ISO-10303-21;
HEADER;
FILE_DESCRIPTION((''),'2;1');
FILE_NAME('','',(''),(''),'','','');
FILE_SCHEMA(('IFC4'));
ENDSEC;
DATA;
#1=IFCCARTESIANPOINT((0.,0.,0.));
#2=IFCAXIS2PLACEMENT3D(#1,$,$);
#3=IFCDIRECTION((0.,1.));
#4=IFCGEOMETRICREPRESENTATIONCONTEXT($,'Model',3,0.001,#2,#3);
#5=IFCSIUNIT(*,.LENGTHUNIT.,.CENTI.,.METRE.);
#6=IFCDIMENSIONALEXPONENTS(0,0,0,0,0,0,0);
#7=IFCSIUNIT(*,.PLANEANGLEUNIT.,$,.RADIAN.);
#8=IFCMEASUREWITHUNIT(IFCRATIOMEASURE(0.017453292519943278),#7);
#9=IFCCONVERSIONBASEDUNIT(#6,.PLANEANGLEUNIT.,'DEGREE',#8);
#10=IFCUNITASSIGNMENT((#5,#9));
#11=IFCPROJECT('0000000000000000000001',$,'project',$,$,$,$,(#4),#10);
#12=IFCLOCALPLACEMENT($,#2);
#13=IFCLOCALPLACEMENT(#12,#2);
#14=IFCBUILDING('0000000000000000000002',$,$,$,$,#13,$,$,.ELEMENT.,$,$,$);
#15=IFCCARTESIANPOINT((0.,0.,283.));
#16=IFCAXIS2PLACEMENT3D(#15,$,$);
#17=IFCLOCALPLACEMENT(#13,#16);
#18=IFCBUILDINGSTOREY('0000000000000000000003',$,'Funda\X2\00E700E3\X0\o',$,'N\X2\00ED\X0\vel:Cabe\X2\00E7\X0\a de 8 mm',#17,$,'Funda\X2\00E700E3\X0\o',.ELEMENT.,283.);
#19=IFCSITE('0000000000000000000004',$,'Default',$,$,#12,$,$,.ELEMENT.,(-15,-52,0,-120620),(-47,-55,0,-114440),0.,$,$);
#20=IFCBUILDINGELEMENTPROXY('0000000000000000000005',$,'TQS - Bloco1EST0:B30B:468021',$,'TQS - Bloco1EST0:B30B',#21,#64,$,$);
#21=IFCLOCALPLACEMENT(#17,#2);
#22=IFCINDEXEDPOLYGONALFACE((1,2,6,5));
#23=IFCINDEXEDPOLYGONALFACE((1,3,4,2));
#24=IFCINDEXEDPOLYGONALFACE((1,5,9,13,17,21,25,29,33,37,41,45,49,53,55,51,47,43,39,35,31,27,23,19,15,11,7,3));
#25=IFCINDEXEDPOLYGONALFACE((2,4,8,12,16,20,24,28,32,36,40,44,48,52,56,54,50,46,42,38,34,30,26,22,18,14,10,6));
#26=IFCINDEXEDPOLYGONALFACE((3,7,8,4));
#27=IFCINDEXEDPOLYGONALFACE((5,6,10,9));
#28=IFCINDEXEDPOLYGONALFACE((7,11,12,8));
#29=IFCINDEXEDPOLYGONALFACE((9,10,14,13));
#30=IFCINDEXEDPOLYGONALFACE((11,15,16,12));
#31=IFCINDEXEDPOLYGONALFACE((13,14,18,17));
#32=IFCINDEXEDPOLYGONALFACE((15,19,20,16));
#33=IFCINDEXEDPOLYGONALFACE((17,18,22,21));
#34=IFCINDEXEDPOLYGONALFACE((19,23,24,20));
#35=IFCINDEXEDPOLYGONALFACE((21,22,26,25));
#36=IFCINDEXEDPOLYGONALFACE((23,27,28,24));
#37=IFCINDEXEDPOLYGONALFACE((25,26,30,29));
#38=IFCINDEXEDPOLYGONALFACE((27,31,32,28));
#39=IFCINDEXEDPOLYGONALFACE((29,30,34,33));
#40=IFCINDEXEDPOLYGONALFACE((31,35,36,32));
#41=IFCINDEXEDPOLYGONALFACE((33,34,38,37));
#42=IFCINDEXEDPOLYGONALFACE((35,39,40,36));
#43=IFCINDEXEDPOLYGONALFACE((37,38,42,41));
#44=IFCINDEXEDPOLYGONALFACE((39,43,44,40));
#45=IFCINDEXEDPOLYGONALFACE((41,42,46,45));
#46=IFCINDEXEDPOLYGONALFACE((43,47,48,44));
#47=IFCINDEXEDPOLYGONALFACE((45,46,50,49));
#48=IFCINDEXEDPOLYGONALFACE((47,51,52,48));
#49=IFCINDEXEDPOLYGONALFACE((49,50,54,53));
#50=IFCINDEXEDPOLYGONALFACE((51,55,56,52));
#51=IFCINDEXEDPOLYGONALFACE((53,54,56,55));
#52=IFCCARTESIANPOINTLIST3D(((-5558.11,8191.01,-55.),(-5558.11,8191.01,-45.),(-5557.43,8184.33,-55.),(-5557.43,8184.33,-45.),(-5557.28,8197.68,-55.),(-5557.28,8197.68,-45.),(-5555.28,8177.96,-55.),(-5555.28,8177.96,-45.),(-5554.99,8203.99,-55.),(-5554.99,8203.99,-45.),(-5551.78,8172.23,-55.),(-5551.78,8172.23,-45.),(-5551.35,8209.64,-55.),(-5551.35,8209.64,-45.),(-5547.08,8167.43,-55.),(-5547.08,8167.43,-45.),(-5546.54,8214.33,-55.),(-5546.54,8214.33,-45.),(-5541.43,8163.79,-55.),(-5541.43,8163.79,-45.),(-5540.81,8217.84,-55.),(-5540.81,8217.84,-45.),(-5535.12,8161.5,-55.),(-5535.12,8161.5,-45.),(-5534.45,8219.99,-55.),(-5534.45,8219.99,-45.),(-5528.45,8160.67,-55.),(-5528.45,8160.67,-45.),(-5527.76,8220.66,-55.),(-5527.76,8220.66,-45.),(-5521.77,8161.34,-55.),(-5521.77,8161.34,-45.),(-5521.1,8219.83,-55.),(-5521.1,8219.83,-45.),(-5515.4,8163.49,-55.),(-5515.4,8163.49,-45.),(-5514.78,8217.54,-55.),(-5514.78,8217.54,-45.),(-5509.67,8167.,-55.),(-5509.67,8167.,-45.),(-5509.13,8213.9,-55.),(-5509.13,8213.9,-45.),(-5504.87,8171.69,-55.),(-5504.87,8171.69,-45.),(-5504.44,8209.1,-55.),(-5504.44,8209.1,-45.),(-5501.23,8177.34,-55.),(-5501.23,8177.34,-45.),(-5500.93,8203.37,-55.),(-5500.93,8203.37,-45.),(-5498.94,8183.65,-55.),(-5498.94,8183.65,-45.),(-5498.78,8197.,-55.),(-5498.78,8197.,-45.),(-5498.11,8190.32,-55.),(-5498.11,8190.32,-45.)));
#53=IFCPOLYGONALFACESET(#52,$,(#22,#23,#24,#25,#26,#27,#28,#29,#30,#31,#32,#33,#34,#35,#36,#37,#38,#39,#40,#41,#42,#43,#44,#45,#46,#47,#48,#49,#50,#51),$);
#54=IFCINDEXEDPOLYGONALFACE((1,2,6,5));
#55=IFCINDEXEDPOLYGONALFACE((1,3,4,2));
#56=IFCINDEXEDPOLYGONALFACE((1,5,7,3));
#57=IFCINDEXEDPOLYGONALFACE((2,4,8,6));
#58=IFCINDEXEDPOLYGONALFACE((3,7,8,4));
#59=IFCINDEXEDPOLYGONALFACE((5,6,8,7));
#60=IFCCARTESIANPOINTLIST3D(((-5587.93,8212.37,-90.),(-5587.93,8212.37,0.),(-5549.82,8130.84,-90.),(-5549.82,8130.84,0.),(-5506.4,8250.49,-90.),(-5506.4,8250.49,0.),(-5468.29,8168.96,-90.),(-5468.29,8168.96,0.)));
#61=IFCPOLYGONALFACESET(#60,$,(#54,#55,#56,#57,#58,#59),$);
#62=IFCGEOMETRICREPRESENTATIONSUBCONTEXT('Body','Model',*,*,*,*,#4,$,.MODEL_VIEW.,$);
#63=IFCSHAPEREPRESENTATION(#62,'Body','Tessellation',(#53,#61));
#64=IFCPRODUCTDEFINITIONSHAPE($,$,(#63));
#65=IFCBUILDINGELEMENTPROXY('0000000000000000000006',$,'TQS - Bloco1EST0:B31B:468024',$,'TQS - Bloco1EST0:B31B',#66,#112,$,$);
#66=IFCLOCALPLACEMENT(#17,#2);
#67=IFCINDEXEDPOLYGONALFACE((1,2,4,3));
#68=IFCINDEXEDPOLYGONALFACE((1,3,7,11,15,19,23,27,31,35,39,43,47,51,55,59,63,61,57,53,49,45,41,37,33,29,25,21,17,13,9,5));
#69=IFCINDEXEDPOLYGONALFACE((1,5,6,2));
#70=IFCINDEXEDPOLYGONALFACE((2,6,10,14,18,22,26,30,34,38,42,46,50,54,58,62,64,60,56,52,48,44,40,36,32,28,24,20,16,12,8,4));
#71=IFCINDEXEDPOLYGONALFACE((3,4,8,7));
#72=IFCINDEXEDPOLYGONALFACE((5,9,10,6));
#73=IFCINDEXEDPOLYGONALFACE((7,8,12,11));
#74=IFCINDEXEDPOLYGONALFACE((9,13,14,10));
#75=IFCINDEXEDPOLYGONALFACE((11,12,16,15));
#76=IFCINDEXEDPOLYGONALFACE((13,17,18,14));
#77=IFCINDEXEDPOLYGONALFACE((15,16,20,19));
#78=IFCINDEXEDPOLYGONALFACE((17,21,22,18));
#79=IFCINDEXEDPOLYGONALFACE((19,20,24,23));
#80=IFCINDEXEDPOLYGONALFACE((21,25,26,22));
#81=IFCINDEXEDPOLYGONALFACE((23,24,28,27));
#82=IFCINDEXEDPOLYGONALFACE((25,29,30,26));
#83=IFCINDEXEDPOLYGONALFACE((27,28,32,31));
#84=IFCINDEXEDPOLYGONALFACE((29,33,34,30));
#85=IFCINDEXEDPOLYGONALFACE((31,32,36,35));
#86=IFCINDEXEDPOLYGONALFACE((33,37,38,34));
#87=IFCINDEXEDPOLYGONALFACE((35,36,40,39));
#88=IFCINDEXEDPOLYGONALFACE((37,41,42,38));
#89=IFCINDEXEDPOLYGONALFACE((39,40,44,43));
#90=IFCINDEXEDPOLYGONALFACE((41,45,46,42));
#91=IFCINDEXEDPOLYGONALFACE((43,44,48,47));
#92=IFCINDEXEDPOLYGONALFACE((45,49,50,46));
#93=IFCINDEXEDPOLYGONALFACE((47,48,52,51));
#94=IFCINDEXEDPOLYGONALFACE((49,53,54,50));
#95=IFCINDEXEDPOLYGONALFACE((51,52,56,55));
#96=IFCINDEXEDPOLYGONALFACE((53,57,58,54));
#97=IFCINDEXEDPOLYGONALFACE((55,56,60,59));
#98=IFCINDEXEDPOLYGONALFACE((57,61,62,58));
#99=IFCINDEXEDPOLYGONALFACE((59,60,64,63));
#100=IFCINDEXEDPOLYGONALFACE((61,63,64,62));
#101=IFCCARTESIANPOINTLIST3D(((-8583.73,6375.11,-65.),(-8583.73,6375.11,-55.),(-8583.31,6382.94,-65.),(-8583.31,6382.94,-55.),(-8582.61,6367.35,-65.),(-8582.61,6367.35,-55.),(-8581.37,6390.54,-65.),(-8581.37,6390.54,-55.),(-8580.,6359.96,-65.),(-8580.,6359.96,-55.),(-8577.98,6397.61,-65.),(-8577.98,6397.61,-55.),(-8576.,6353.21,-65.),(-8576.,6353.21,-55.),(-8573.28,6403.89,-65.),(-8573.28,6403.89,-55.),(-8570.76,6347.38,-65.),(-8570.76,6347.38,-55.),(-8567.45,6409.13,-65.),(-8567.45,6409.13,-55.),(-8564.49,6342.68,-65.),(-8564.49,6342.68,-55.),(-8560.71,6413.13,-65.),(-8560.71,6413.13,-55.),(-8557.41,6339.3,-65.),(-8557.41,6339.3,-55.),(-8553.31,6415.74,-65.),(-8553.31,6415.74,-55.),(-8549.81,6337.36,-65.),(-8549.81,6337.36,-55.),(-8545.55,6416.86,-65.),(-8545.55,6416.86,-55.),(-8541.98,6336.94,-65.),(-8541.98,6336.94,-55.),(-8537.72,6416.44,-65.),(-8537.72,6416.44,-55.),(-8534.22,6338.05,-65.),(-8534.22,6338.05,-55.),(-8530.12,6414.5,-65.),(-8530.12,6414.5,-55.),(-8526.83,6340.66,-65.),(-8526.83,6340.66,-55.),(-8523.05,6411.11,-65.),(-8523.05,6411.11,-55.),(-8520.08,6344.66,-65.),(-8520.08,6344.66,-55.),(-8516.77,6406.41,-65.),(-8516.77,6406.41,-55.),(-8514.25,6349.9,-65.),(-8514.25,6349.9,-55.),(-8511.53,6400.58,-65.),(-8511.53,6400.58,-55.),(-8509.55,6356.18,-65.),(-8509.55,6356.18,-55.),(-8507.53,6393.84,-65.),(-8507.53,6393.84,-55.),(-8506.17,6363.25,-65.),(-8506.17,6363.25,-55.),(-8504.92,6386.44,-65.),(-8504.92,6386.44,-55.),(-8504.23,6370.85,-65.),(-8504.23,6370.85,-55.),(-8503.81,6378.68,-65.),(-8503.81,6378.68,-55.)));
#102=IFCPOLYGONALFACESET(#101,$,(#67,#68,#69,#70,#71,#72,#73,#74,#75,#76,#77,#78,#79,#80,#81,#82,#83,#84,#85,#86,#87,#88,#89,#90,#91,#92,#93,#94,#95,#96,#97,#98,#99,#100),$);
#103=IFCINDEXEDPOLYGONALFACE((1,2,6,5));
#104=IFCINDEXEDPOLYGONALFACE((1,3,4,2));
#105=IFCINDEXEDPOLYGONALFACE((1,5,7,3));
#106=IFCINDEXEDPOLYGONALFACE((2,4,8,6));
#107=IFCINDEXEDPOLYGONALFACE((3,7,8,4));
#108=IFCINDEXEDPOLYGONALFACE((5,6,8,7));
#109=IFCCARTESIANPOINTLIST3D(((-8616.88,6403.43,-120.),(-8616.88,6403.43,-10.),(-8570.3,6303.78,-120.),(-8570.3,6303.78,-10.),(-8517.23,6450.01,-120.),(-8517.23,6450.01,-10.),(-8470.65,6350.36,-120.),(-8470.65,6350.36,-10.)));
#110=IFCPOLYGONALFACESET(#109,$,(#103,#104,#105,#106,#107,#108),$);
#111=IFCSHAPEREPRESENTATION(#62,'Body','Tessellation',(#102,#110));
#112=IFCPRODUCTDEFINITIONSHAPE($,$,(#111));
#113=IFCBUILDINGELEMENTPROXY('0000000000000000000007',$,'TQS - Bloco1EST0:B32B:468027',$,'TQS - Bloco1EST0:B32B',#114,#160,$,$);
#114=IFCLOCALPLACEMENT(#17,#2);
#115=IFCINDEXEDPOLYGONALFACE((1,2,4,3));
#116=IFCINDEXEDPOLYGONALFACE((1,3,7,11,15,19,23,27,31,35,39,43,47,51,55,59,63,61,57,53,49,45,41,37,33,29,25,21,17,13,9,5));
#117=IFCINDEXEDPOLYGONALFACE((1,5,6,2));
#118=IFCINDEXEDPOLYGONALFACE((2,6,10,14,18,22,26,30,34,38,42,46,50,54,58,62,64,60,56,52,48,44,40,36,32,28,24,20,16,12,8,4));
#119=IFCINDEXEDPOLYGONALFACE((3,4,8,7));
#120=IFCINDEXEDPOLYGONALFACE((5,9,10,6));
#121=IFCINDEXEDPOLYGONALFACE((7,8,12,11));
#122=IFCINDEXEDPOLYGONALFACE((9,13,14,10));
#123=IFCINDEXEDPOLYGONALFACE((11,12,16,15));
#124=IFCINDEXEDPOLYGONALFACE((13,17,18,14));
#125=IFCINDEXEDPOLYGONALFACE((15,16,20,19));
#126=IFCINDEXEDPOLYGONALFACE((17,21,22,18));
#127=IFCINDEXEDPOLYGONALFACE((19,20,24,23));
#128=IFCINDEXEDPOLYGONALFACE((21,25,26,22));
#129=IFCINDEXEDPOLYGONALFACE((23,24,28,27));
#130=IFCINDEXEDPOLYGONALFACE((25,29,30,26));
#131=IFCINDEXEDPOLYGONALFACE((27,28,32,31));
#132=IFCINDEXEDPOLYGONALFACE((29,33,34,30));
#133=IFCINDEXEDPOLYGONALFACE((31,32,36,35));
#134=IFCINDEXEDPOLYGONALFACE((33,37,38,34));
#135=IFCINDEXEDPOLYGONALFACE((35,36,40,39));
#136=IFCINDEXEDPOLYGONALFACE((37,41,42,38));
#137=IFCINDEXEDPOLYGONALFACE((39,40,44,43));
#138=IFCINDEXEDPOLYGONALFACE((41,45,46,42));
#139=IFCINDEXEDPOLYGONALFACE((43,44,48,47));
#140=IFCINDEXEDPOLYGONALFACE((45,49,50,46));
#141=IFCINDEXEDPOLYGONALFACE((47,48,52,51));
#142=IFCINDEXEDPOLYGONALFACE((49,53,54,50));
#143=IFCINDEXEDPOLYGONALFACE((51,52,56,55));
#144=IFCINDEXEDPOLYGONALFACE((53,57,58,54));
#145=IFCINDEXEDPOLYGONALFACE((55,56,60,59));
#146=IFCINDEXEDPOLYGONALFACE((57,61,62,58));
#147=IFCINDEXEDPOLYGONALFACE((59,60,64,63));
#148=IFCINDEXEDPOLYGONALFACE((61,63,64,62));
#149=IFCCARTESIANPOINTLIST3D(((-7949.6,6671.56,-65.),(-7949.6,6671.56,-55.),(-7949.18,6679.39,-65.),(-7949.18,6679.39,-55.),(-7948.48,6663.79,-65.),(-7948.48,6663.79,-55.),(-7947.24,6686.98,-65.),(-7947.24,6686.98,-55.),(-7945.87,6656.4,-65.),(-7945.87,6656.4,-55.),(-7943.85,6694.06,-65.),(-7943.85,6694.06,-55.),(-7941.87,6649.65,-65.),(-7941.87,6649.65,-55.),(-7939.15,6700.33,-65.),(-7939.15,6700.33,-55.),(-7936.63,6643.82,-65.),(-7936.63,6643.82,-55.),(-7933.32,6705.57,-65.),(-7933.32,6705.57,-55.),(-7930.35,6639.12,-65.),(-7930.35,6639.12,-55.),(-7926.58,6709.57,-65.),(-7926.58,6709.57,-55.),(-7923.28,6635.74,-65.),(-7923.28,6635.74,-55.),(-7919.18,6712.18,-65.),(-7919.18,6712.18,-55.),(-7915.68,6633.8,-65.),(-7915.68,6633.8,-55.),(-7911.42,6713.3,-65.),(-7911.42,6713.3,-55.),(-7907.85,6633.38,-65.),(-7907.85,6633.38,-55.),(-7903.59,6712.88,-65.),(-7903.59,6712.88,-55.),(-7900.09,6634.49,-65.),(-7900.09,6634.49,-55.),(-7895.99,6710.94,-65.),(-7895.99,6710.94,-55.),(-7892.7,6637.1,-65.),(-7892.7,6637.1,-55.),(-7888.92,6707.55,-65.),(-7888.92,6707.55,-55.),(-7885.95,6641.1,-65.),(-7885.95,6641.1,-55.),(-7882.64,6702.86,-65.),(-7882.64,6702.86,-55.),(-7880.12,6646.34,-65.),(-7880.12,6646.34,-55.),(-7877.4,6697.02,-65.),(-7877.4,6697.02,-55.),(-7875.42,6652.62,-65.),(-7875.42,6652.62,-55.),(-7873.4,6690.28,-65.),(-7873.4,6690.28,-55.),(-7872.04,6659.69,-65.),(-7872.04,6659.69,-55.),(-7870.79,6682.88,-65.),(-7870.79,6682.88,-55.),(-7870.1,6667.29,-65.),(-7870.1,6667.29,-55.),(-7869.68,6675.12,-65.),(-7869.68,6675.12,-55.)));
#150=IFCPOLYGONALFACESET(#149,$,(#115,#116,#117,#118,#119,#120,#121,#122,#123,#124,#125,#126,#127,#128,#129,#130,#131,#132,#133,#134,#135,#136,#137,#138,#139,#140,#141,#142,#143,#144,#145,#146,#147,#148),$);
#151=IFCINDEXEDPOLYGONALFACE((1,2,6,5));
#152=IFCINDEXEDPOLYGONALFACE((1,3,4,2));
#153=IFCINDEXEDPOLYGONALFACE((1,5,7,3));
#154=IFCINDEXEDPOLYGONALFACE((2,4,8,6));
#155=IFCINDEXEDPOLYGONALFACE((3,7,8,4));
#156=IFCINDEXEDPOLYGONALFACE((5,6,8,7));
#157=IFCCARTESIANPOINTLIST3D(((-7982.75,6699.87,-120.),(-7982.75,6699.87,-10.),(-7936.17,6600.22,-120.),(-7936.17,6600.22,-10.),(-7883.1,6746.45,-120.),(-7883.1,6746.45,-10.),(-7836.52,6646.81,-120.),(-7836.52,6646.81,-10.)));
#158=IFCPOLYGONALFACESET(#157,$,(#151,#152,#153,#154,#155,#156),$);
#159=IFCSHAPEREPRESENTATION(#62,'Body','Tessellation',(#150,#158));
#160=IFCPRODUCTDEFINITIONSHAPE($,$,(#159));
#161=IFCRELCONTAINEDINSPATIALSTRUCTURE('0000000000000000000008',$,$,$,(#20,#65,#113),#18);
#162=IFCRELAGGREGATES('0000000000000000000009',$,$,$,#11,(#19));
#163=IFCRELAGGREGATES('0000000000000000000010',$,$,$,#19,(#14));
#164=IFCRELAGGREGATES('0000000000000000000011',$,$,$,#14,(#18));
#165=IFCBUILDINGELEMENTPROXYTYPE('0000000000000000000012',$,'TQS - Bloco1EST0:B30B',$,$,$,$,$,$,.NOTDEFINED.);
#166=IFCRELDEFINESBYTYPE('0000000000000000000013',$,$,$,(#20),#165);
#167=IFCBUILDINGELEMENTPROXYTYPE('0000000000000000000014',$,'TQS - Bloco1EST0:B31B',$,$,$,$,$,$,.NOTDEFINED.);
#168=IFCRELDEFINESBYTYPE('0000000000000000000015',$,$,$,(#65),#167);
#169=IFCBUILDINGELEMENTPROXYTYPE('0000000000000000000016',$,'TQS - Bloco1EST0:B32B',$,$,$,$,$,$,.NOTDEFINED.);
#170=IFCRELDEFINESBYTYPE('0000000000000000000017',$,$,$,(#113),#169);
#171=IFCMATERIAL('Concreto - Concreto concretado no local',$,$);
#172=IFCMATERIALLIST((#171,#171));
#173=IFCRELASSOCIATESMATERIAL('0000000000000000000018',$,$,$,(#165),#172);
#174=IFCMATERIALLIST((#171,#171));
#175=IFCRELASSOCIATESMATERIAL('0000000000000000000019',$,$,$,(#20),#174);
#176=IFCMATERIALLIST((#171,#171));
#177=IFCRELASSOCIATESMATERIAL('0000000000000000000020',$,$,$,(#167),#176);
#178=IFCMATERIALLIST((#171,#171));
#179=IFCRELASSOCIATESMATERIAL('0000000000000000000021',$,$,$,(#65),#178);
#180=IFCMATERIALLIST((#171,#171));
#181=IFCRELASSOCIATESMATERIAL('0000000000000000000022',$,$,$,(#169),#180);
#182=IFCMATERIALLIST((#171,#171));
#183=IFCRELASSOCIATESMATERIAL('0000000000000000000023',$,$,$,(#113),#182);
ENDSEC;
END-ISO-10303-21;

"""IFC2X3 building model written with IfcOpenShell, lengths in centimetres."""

from ifc_helpers import new_model, entity, si_unit, converted_unit, direction, frame, frame_2d, origin, origin_2d_with_axis, place, context, subcontext, project, spatial, rectangle, circle, extrude, source, transform, mapped, material, material_list, type_object, type_shapes, element, save


model = new_model("IFC2X3")

# Units and contexts
model_context = context("Model", 3, precision=0.001, world=origin(), true_north=direction((0.0, 1.0)))
body_context = subcontext(model_context, "Body", "Model", "MODEL_VIEW")
ifc_project = project(units=[si_unit("LENGTHUNIT", "METRE", prefix="CENTI"), converted_unit("PLANEANGLEUNIT", "DEGREE", entity("IfcRatioMeasure", 0.017453292519943278), si_unit("PLANEANGLEUNIT", "RADIAN"), dimensions=[0, 0, 0, 0, 0, 0, 0])], contexts=[model_context])

# Site, building, storey
site_placement = place(None, origin())
site = spatial("IfcSite", under=ifc_project, at=site_placement, Name="Default", CompositionType="ELEMENT", RefLatitude=(-15, -52, 0, -120620), RefLongitude=(-47, -55, 0, -114440), RefElevation=0.0)
building_placement = place(site_placement, origin())
building = spatial("IfcBuilding", under=site, at=building_placement, CompositionType="ELEMENT")
storey_placement = place(building_placement, frame((0.0, 0.0, 283.0)))
storey = spatial("IfcBuildingStorey", under=building, at=storey_placement, Name="Fundação", ObjectType="Nível:Cabeça de 8 mm", LongName="Fundação", CompositionType="ELEMENT", Elevation=283.0)

# Building element proxies
ifc_material_1 = material(Name="Concreto - Concreto concretado no local")
ifc_material_list_1 = material_list([ifc_material_1, ifc_material_1])
ifc_material_list_2 = material_list([ifc_material_1, ifc_material_1])
building_element_proxy_type_1 = type_object("IfcBuildingElementProxyType", Name="TQS - Bloco1EST0:B30B", PredefinedType="NOTDEFINED", material=ifc_material_list_2)
shared_shape_1 = source(origin(), body_context, "Body", "SweptSolid", [
    extrude(circle(Radius=30.0, at=frame_2d((0.0, 0.0), x_axis=(1.0, 0.0))), frame((0.0, 0.0, -55.0)), (0.0, 0.0, 1.0), 10.0),
    extrude(rectangle(XDim=90.0, YDim=90.0, at=origin_2d_with_axis()), frame((0.0, 0.0, -90.0), z_axis=(0.0, 0.0, 1.0), x_axis=(-1.0, 0.0, 0.0)), (0.0, 0.0, 1.0), 90.0),
])
type_shapes(building_element_proxy_type_1, [shared_shape_1])
proxy_1_placement = place(storey_placement, frame((-5528.11, 8190.66, 0.0), z_axis=(0.0, 0.0, 1.0), x_axis=(0.905902, 0.423488, 0.0)))
element("IfcBuildingElementProxy", 1, at=proxy_1_placement, inside=storey, type_object=building_element_proxy_type_1, material=ifc_material_list_1, Name="TQS - Bloco1EST0:B30B:468021", ObjectType="TQS - Bloco1EST0:B30B", context=body_context, shape_type="MappedRepresentation", body=[
    mapped(shared_shape_1, transform((0.0, 0.0, 0.0), scale=1.0)),
])
ifc_material_list_3 = material_list([ifc_material_1, ifc_material_1])
ifc_material_list_4 = material_list([ifc_material_1, ifc_material_1])
building_element_proxy_type_2 = type_object("IfcBuildingElementProxyType", Name="TQS - Bloco1EST0:B31B", PredefinedType="NOTDEFINED", material=ifc_material_list_4)
shared_shape_2 = source(origin(), body_context, "Body", "SweptSolid", [
    extrude(circle(Radius=40.0, at=frame_2d((0.0, 0.0), x_axis=(1.0, 0.0))), frame((0.0, 0.0, -55.0)), (0.0, 0.0, 1.0), 10.0),
    extrude(rectangle(XDim=110.0, YDim=110.0, at=origin_2d_with_axis()), frame((0.0, 0.0, -110.0), z_axis=(0.0, 0.0, 1.0), x_axis=(-1.0, 0.0, 0.0)), (0.0, 0.0, 1.0), 110.0),
])
type_shapes(building_element_proxy_type_2, [shared_shape_2])
proxy_2_placement = place(storey_placement, frame((-8543.77, 6376.9, -10.0), z_axis=(0.0, 0.0, 1.0), x_axis=(0.905902, 0.423488, 0.0)))
element("IfcBuildingElementProxy", 2, at=proxy_2_placement, inside=storey, type_object=building_element_proxy_type_2, material=ifc_material_list_3, Name="TQS - Bloco1EST0:B31B:468024", ObjectType="TQS - Bloco1EST0:B31B", context=body_context, shape_type="MappedRepresentation", body=[
    mapped(shared_shape_2, transform((0.0, 0.0, 0.0), scale=1.0)),
])
ifc_material_list_5 = material_list([ifc_material_1, ifc_material_1])
ifc_material_list_6 = material_list([ifc_material_1, ifc_material_1])
building_element_proxy_type_3 = type_object("IfcBuildingElementProxyType", Name="TQS - Bloco1EST0:B32B", PredefinedType="NOTDEFINED", material=ifc_material_list_6)
shared_shape_3 = source(origin(), body_context, "Body", "SweptSolid", [
    extrude(circle(Radius=40.0, at=frame_2d((0.0, 0.0), x_axis=(1.0, 0.0))), frame((0.0, 0.0, -55.0)), (0.0, 0.0, 1.0), 10.0),
    extrude(rectangle(XDim=110.0, YDim=110.0, at=origin_2d_with_axis()), frame((0.0, 0.0, -110.0), z_axis=(0.0, 0.0, 1.0), x_axis=(-1.0, 0.0, 0.0)), (0.0, 0.0, 1.0), 110.0),
])
type_shapes(building_element_proxy_type_3, [shared_shape_3])
proxy_3_placement = place(storey_placement, frame((-7909.64, 6673.34, -10.0), z_axis=(0.0, 0.0, 1.0), x_axis=(0.905902, 0.423488, 0.0)))
element("IfcBuildingElementProxy", 3, at=proxy_3_placement, inside=storey, type_object=building_element_proxy_type_3, material=ifc_material_list_5, Name="TQS - Bloco1EST0:B32B:468027", ObjectType="TQS - Bloco1EST0:B32B", context=body_context, shape_type="MappedRepresentation", body=[
    mapped(shared_shape_3, transform((0.0, 0.0, 0.0), scale=1.0)),
])

save(model, "model.ifc")
